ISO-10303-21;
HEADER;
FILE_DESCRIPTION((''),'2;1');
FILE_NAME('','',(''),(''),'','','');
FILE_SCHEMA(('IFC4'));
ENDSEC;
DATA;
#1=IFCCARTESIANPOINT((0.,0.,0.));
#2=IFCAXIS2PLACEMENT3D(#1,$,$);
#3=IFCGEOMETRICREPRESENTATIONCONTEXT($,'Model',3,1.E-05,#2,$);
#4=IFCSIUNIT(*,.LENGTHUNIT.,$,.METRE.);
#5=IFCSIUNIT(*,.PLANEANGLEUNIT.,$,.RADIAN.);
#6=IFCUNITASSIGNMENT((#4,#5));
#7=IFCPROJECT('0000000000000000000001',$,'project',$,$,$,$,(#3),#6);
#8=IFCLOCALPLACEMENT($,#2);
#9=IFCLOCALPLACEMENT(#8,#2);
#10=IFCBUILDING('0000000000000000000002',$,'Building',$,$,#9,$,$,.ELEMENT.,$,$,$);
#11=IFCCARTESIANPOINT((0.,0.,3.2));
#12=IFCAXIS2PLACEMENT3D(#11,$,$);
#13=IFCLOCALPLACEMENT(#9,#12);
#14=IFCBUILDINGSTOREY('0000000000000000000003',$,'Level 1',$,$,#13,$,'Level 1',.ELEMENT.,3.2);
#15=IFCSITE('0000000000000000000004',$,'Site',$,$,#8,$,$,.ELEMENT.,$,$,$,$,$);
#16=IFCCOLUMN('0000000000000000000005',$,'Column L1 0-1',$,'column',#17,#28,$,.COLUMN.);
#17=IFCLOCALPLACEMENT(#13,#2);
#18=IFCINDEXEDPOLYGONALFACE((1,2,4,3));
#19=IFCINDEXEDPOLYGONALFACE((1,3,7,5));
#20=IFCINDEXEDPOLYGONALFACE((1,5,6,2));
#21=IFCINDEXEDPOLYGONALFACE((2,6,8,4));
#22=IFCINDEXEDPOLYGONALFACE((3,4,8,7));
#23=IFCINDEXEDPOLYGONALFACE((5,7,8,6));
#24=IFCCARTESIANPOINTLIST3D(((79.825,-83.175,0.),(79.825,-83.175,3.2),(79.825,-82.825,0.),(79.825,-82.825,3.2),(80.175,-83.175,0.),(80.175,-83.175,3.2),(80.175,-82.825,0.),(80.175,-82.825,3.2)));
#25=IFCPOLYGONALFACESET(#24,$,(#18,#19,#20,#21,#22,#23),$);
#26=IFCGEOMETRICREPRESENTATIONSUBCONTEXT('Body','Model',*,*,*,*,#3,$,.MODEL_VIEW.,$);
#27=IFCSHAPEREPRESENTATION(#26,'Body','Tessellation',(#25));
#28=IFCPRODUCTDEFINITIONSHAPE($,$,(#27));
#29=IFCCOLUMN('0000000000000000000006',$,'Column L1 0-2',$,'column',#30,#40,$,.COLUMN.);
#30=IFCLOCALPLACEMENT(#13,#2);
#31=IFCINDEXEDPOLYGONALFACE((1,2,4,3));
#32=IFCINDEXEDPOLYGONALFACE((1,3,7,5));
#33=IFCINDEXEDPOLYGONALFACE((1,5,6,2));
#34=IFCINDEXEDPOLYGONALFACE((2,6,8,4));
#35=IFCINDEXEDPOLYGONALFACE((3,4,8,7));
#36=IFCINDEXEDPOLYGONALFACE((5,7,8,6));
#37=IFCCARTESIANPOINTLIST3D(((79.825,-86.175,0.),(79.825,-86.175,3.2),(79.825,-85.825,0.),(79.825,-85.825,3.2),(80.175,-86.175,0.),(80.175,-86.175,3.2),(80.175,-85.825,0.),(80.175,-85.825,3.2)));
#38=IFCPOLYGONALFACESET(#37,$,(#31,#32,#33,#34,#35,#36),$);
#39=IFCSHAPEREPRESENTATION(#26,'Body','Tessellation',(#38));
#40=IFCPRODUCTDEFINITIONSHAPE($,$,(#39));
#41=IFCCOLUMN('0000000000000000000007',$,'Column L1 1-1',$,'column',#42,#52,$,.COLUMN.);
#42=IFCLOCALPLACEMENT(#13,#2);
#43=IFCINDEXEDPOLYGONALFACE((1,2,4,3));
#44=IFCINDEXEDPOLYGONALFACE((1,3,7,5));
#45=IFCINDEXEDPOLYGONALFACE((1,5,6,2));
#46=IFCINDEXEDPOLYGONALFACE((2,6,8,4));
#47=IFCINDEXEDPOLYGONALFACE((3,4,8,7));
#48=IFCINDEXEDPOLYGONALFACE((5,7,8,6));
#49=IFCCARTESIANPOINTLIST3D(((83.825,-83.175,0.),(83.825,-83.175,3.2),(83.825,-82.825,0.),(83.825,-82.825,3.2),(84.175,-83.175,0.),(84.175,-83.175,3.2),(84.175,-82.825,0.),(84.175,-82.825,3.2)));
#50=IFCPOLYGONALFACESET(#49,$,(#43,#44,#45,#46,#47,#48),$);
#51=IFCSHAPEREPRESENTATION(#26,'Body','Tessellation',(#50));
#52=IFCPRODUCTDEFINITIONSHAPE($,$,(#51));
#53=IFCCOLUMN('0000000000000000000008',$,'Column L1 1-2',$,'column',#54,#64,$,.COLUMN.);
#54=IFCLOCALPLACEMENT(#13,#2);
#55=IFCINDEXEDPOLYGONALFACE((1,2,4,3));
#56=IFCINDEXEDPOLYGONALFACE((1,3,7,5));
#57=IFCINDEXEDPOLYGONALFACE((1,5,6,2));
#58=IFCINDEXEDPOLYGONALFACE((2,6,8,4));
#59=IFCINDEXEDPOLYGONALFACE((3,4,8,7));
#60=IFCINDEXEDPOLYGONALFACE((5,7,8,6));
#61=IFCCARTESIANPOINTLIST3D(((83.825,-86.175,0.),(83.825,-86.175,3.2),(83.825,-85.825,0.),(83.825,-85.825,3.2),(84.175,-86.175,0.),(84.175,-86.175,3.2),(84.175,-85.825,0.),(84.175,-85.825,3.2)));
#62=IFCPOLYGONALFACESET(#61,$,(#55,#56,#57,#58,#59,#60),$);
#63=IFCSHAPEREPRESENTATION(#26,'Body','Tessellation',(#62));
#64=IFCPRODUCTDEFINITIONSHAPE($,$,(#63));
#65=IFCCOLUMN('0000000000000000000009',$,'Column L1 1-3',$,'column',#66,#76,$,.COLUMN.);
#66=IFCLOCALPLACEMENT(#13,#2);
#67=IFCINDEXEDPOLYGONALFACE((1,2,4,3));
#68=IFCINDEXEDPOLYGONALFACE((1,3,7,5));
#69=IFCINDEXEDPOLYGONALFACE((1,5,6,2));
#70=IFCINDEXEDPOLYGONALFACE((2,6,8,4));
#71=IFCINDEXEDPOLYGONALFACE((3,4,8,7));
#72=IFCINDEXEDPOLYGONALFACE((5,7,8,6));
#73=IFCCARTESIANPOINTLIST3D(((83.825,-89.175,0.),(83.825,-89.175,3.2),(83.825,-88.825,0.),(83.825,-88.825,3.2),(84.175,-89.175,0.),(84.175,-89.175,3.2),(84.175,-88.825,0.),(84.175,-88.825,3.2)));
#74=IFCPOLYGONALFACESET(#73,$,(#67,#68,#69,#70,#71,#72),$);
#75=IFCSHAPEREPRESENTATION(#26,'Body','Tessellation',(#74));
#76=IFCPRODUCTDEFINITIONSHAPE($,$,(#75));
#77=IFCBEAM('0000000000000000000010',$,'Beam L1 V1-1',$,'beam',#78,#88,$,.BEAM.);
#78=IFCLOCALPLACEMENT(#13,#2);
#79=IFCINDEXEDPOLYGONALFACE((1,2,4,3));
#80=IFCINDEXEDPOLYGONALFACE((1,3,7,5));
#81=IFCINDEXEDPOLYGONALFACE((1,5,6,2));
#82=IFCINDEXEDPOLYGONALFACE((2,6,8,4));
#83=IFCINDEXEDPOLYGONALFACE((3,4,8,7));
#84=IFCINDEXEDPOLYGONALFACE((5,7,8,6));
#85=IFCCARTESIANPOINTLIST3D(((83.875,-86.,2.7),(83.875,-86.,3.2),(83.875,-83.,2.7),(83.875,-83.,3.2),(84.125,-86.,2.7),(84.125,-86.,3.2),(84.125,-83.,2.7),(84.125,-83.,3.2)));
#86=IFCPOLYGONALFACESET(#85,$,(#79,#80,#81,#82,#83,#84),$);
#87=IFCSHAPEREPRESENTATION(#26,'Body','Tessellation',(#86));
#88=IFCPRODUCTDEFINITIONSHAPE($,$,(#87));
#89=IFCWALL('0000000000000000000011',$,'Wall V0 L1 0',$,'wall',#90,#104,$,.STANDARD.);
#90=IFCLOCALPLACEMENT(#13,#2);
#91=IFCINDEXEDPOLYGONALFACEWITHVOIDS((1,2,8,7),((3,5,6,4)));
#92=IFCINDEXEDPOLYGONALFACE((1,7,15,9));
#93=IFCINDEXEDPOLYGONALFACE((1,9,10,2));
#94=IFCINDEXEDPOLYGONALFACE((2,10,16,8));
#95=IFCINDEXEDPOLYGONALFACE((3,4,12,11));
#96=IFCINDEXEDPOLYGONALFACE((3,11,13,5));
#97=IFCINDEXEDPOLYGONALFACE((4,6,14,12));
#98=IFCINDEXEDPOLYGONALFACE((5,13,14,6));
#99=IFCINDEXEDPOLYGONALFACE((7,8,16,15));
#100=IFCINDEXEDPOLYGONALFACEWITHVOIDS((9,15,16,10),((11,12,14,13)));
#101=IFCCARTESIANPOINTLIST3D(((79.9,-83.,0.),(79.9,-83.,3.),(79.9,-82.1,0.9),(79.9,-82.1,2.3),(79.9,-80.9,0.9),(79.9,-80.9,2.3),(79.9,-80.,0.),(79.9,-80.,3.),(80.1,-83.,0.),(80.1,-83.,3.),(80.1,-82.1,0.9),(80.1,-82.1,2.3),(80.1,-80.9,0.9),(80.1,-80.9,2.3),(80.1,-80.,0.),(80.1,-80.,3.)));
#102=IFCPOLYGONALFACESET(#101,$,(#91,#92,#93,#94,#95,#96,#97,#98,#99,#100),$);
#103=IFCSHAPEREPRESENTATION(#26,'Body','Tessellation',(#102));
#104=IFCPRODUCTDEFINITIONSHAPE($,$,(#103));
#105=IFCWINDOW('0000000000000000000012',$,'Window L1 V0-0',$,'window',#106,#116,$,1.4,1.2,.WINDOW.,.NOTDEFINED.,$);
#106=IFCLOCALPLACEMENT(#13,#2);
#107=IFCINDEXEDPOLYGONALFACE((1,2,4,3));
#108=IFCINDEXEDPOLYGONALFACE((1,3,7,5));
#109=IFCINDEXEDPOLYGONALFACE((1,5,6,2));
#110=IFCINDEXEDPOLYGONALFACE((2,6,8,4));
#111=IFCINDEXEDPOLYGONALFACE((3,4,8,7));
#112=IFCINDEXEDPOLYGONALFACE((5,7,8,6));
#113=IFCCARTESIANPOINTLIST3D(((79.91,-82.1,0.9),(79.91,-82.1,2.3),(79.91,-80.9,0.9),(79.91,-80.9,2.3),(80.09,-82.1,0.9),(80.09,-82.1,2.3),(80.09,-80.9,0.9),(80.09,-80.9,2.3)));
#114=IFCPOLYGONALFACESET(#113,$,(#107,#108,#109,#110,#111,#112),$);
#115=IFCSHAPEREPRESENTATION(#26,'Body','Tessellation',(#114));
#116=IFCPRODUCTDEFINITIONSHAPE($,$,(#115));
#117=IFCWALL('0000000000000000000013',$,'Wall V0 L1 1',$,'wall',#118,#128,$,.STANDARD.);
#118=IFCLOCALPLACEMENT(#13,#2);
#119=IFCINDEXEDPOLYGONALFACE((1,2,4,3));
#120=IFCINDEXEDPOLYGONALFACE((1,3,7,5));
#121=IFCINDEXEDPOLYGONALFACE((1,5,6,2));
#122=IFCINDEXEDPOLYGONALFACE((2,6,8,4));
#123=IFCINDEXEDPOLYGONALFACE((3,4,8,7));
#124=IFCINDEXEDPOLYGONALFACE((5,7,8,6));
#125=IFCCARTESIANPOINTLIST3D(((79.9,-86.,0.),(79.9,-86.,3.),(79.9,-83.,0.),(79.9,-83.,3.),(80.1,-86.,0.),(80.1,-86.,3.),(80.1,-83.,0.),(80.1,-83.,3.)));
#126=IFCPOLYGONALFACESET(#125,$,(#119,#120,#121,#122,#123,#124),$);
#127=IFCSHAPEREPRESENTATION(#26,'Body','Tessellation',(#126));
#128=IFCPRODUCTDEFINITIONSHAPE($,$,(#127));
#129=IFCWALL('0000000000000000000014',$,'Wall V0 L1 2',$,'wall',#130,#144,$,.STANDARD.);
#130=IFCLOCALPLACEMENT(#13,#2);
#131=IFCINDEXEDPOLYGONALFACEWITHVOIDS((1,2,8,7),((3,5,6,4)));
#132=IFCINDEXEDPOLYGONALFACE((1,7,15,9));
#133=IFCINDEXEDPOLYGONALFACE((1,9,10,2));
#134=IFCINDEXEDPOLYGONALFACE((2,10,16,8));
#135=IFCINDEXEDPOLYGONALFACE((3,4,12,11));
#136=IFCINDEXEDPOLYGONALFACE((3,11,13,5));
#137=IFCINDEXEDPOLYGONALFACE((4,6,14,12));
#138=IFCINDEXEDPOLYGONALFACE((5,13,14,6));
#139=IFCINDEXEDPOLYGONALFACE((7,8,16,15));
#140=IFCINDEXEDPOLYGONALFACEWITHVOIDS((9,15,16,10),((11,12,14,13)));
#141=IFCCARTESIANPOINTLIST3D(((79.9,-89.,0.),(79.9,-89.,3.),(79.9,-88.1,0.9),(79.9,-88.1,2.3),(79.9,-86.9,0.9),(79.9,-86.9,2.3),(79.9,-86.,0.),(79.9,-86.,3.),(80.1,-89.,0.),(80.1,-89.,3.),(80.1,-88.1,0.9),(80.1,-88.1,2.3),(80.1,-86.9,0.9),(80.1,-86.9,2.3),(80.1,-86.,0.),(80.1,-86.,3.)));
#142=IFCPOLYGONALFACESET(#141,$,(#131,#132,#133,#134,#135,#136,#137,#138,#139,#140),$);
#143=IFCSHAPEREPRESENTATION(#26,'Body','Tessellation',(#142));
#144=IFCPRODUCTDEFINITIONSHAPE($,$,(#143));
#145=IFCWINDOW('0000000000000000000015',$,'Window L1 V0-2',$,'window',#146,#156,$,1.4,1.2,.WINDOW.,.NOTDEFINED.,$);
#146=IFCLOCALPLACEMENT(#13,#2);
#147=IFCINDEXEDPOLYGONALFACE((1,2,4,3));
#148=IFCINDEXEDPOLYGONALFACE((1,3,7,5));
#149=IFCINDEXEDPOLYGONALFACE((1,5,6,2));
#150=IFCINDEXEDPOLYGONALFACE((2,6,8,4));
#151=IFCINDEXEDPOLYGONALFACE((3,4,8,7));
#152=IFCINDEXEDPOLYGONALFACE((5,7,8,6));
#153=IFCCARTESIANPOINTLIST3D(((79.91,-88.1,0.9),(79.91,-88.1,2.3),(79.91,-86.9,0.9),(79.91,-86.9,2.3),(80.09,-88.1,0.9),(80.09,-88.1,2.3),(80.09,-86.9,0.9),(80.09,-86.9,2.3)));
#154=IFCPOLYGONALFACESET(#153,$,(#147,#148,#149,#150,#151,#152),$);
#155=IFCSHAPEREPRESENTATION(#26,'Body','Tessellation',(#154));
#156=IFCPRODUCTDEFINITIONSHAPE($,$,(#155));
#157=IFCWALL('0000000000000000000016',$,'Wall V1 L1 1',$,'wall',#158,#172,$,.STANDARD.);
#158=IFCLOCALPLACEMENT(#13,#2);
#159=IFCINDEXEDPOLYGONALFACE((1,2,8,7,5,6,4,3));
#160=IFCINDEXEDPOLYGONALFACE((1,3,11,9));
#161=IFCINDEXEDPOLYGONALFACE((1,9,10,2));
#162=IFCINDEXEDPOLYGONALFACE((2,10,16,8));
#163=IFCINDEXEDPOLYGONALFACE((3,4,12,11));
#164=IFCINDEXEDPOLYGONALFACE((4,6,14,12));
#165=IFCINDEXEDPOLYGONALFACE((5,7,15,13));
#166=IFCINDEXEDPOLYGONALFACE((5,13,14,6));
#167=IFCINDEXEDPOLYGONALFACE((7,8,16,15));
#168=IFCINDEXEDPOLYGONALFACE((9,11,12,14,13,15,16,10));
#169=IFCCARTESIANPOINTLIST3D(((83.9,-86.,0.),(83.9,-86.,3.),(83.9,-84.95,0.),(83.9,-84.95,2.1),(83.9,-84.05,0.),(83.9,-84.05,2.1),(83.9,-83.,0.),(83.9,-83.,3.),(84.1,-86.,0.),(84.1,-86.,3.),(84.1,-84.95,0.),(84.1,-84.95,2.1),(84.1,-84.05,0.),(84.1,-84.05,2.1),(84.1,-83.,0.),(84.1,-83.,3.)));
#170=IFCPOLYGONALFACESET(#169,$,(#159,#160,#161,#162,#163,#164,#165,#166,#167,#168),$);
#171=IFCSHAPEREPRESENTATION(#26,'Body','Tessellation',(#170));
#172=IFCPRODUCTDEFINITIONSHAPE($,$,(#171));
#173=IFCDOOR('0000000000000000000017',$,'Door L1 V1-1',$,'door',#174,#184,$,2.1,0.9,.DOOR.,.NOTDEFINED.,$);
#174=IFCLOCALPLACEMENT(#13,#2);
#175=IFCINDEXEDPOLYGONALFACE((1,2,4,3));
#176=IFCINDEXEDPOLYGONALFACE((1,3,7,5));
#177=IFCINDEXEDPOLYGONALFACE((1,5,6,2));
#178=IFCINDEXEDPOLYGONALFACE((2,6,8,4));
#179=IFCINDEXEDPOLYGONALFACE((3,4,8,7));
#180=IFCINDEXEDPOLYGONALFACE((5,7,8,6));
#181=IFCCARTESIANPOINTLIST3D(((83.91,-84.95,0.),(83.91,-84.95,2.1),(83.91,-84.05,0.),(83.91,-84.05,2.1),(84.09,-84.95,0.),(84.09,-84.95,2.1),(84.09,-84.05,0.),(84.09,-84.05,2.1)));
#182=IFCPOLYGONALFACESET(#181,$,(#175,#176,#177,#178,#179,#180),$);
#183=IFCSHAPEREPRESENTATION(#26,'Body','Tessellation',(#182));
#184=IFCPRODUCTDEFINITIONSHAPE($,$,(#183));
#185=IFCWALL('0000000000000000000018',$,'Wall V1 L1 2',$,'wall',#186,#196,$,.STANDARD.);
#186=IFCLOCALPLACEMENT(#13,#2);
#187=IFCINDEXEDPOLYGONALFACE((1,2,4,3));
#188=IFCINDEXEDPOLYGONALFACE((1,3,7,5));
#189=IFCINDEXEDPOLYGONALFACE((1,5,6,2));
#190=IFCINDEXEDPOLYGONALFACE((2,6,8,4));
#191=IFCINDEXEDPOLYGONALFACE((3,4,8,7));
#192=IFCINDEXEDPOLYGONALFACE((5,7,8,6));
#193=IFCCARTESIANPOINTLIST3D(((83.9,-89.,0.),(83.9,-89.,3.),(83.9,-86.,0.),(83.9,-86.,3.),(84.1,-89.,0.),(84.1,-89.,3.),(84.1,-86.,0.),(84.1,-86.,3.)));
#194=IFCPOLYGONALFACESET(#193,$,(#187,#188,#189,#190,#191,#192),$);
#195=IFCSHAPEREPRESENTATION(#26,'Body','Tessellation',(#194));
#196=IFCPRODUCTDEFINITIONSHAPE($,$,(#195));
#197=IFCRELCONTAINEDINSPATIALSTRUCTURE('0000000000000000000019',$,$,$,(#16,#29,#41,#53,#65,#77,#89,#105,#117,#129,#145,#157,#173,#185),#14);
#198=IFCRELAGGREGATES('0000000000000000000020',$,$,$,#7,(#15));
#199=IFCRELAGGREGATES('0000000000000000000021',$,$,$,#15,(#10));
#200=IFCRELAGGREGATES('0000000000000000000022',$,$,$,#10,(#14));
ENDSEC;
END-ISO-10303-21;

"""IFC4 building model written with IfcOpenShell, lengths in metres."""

from ifc_helpers import new_model, si_unit, frame, frame_2d, origin, origin_2d, place, context, subcontext, project, spatial, rectangle, extrude, element, fill, save


model = new_model("IFC4")

# Units and contexts
model_context = context("Model", 3, precision=1e-05, world=origin())
body_context = subcontext(model_context, "Body", "Model", "MODEL_VIEW")
ifc_project = project(units=[si_unit("LENGTHUNIT", "METRE"), si_unit("PLANEANGLEUNIT", "RADIAN")], contexts=[model_context])

# Site, building, storey
site_placement = place(None, origin())
site = spatial("IfcSite", under=ifc_project, at=site_placement, Name="Site", CompositionType="ELEMENT")
building_placement = place(site_placement, origin())
building = spatial("IfcBuilding", under=site, at=building_placement, Name="Building", CompositionType="ELEMENT")
storey_placement = place(building_placement, frame((0.0, 0.0, 3.2)))
storey = spatial("IfcBuildingStorey", under=building, at=storey_placement, Name="Level 1", LongName="Level 1", CompositionType="ELEMENT", Elevation=3.2)

# Columns
for number, where, name in (
    (1, (80.0, -83.0, 0.0), "Column L1 0-1"),
    (2, (80.0, -86.0, 0.0), "Column L1 0-2"),
    (3, (84.0, -83.0, 0.0), "Column L1 1-1"),
    (4, (84.0, -86.0, 0.0), "Column L1 1-2"),
    (5, (84.0, -89.0, 0.0), "Column L1 1-3"),
):
    element("IfcColumn", number, at=place(storey_placement, frame(where)), inside=storey, Name=name, ObjectType="column", PredefinedType="COLUMN", context=body_context, shape_type="SweptSolid", body=[
        extrude(rectangle(XDim=0.35, YDim=0.35, at=origin_2d()), origin(), (0.0, 0.0, 1.0), 3.2),
    ])

# Beam
beam_placement = place(storey_placement, frame((84.0, -83.0, 2.95), z_axis=(0.0, -1.0, 0.0), x_axis=(0.0, 0.0, 1.0)))
element("IfcBeam", 6, at=beam_placement, inside=storey, Name="Beam L1 V1-1", ObjectType="beam", PredefinedType="BEAM", context=body_context, shape_type="SweptSolid", body=[
    extrude(rectangle(XDim=0.5, YDim=0.25, at=origin_2d()), origin(), (0.0, 0.0, 1.0), 3.0),
])

# Wall, opening, window
wall_1_placement = place(storey_placement, frame((80.0, -80.0, 0.0), z_axis=(0.0, 0.0, 1.0), x_axis=(0.0, -1.0, 0.0)))
wall_1 = element("IfcWall", 7, at=wall_1_placement, inside=storey, Name="Wall V0 L1 0", ObjectType="wall", PredefinedType="STANDARD", context=body_context, shape_type="SweptSolid", body=[
    extrude(rectangle(XDim=3.0, YDim=0.2, at=frame_2d((1.5, 0.0))), origin(), (0.0, 0.0, 1.0), 3.0),
])
opening_1_placement = place(storey_placement, frame((80.0, -81.5, 0.9), z_axis=(0.0, 0.0, 1.0), x_axis=(0.0, -1.0, 0.0)))
opening_1 = element("IfcOpeningElement", 8, at=opening_1_placement, cuts=wall_1, ObjectType="Opening", PredefinedType="OPENING", context=body_context, shape_type="SweptSolid", body=[
    extrude(rectangle(XDim=1.2, YDim=0.22, at=origin_2d()), origin(), (0.0, 0.0, 1.0), 1.4),
])
window_1_placement = place(storey_placement, frame((80.0, -81.5, 0.9), z_axis=(0.0, 0.0, 1.0), x_axis=(0.0, -1.0, 0.0)))
window_1 = element("IfcWindow", 9, at=window_1_placement, inside=storey, Name="Window L1 V0-0", ObjectType="window", OverallHeight=1.4, OverallWidth=1.2, PartitioningType="NOTDEFINED", PredefinedType="WINDOW", context=body_context, shape_type="SweptSolid", body=[
    extrude(rectangle(XDim=1.2, YDim=0.18, at=origin_2d()), origin(), (0.0, 0.0, 1.0), 1.4),
])
fill(opening_1, window_1)

# Wall
wall_2_placement = place(storey_placement, frame((80.0, -83.0, 0.0), z_axis=(0.0, 0.0, 1.0), x_axis=(0.0, -1.0, 0.0)))
element("IfcWall", 10, at=wall_2_placement, inside=storey, Name="Wall V0 L1 1", ObjectType="wall", PredefinedType="STANDARD", context=body_context, shape_type="SweptSolid", body=[
    extrude(rectangle(XDim=3.0, YDim=0.2, at=frame_2d((1.5, 0.0))), origin(), (0.0, 0.0, 1.0), 3.0),
])

# Wall, opening, window
wall_3_placement = place(storey_placement, frame((80.0, -86.0, 0.0), z_axis=(0.0, 0.0, 1.0), x_axis=(0.0, -1.0, 0.0)))
wall_3 = element("IfcWall", 11, at=wall_3_placement, inside=storey, Name="Wall V0 L1 2", ObjectType="wall", PredefinedType="STANDARD", context=body_context, shape_type="SweptSolid", body=[
    extrude(rectangle(XDim=3.0, YDim=0.2, at=frame_2d((1.5, 0.0))), origin(), (0.0, 0.0, 1.0), 3.0),
])
opening_2_placement = place(storey_placement, frame((80.0, -87.5, 0.9), z_axis=(0.0, 0.0, 1.0), x_axis=(0.0, -1.0, 0.0)))
opening_2 = element("IfcOpeningElement", 12, at=opening_2_placement, cuts=wall_3, ObjectType="Opening", PredefinedType="OPENING", context=body_context, shape_type="SweptSolid", body=[
    extrude(rectangle(XDim=1.2, YDim=0.22, at=origin_2d()), origin(), (0.0, 0.0, 1.0), 1.4),
])
window_2_placement = place(storey_placement, frame((80.0, -87.5, 0.9), z_axis=(0.0, 0.0, 1.0), x_axis=(0.0, -1.0, 0.0)))
window_2 = element("IfcWindow", 13, at=window_2_placement, inside=storey, Name="Window L1 V0-2", ObjectType="window", OverallHeight=1.4, OverallWidth=1.2, PartitioningType="NOTDEFINED", PredefinedType="WINDOW", context=body_context, shape_type="SweptSolid", body=[
    extrude(rectangle(XDim=1.2, YDim=0.18, at=origin_2d()), origin(), (0.0, 0.0, 1.0), 1.4),
])
fill(opening_2, window_2)

# Wall, opening, door
wall_4_placement = place(storey_placement, frame((84.0, -83.0, 0.0), z_axis=(0.0, 0.0, 1.0), x_axis=(0.0, -1.0, 0.0)))
wall_4 = element("IfcWall", 14, at=wall_4_placement, inside=storey, Name="Wall V1 L1 1", ObjectType="wall", PredefinedType="STANDARD", context=body_context, shape_type="SweptSolid", body=[
    extrude(rectangle(XDim=3.0, YDim=0.2, at=frame_2d((1.5, 0.0))), origin(), (0.0, 0.0, 1.0), 3.0),
])
opening_3_placement = place(storey_placement, frame((84.0, -84.5, 0.0), z_axis=(0.0, 0.0, 1.0), x_axis=(0.0, -1.0, 0.0)))
opening_3 = element("IfcOpeningElement", 15, at=opening_3_placement, cuts=wall_4, ObjectType="Opening", PredefinedType="OPENING", context=body_context, shape_type="SweptSolid", body=[
    extrude(rectangle(XDim=0.9, YDim=0.22, at=origin_2d()), origin(), (0.0, 0.0, 1.0), 2.1),
])
door_placement = place(storey_placement, frame((84.0, -84.5, 0.0), z_axis=(0.0, 0.0, 1.0), x_axis=(0.0, -1.0, 0.0)))
door = element("IfcDoor", 16, at=door_placement, inside=storey, Name="Door L1 V1-1", ObjectType="door", OperationType="NOTDEFINED", OverallHeight=2.1, OverallWidth=0.9, PredefinedType="DOOR", context=body_context, shape_type="SweptSolid", body=[
    extrude(rectangle(XDim=0.9, YDim=0.18, at=origin_2d()), origin(), (0.0, 0.0, 1.0), 2.1),
])
fill(opening_3, door)

# Wall
wall_5_placement = place(storey_placement, frame((84.0, -86.0, 0.0), z_axis=(0.0, 0.0, 1.0), x_axis=(0.0, -1.0, 0.0)))
element("IfcWall", 17, at=wall_5_placement, inside=storey, Name="Wall V1 L1 2", ObjectType="wall", PredefinedType="STANDARD", context=body_context, shape_type="SweptSolid", body=[
    extrude(rectangle(XDim=3.0, YDim=0.2, at=frame_2d((1.5, 0.0))), origin(), (0.0, 0.0, 1.0), 3.0),
])

save(model, "model.ifc")
